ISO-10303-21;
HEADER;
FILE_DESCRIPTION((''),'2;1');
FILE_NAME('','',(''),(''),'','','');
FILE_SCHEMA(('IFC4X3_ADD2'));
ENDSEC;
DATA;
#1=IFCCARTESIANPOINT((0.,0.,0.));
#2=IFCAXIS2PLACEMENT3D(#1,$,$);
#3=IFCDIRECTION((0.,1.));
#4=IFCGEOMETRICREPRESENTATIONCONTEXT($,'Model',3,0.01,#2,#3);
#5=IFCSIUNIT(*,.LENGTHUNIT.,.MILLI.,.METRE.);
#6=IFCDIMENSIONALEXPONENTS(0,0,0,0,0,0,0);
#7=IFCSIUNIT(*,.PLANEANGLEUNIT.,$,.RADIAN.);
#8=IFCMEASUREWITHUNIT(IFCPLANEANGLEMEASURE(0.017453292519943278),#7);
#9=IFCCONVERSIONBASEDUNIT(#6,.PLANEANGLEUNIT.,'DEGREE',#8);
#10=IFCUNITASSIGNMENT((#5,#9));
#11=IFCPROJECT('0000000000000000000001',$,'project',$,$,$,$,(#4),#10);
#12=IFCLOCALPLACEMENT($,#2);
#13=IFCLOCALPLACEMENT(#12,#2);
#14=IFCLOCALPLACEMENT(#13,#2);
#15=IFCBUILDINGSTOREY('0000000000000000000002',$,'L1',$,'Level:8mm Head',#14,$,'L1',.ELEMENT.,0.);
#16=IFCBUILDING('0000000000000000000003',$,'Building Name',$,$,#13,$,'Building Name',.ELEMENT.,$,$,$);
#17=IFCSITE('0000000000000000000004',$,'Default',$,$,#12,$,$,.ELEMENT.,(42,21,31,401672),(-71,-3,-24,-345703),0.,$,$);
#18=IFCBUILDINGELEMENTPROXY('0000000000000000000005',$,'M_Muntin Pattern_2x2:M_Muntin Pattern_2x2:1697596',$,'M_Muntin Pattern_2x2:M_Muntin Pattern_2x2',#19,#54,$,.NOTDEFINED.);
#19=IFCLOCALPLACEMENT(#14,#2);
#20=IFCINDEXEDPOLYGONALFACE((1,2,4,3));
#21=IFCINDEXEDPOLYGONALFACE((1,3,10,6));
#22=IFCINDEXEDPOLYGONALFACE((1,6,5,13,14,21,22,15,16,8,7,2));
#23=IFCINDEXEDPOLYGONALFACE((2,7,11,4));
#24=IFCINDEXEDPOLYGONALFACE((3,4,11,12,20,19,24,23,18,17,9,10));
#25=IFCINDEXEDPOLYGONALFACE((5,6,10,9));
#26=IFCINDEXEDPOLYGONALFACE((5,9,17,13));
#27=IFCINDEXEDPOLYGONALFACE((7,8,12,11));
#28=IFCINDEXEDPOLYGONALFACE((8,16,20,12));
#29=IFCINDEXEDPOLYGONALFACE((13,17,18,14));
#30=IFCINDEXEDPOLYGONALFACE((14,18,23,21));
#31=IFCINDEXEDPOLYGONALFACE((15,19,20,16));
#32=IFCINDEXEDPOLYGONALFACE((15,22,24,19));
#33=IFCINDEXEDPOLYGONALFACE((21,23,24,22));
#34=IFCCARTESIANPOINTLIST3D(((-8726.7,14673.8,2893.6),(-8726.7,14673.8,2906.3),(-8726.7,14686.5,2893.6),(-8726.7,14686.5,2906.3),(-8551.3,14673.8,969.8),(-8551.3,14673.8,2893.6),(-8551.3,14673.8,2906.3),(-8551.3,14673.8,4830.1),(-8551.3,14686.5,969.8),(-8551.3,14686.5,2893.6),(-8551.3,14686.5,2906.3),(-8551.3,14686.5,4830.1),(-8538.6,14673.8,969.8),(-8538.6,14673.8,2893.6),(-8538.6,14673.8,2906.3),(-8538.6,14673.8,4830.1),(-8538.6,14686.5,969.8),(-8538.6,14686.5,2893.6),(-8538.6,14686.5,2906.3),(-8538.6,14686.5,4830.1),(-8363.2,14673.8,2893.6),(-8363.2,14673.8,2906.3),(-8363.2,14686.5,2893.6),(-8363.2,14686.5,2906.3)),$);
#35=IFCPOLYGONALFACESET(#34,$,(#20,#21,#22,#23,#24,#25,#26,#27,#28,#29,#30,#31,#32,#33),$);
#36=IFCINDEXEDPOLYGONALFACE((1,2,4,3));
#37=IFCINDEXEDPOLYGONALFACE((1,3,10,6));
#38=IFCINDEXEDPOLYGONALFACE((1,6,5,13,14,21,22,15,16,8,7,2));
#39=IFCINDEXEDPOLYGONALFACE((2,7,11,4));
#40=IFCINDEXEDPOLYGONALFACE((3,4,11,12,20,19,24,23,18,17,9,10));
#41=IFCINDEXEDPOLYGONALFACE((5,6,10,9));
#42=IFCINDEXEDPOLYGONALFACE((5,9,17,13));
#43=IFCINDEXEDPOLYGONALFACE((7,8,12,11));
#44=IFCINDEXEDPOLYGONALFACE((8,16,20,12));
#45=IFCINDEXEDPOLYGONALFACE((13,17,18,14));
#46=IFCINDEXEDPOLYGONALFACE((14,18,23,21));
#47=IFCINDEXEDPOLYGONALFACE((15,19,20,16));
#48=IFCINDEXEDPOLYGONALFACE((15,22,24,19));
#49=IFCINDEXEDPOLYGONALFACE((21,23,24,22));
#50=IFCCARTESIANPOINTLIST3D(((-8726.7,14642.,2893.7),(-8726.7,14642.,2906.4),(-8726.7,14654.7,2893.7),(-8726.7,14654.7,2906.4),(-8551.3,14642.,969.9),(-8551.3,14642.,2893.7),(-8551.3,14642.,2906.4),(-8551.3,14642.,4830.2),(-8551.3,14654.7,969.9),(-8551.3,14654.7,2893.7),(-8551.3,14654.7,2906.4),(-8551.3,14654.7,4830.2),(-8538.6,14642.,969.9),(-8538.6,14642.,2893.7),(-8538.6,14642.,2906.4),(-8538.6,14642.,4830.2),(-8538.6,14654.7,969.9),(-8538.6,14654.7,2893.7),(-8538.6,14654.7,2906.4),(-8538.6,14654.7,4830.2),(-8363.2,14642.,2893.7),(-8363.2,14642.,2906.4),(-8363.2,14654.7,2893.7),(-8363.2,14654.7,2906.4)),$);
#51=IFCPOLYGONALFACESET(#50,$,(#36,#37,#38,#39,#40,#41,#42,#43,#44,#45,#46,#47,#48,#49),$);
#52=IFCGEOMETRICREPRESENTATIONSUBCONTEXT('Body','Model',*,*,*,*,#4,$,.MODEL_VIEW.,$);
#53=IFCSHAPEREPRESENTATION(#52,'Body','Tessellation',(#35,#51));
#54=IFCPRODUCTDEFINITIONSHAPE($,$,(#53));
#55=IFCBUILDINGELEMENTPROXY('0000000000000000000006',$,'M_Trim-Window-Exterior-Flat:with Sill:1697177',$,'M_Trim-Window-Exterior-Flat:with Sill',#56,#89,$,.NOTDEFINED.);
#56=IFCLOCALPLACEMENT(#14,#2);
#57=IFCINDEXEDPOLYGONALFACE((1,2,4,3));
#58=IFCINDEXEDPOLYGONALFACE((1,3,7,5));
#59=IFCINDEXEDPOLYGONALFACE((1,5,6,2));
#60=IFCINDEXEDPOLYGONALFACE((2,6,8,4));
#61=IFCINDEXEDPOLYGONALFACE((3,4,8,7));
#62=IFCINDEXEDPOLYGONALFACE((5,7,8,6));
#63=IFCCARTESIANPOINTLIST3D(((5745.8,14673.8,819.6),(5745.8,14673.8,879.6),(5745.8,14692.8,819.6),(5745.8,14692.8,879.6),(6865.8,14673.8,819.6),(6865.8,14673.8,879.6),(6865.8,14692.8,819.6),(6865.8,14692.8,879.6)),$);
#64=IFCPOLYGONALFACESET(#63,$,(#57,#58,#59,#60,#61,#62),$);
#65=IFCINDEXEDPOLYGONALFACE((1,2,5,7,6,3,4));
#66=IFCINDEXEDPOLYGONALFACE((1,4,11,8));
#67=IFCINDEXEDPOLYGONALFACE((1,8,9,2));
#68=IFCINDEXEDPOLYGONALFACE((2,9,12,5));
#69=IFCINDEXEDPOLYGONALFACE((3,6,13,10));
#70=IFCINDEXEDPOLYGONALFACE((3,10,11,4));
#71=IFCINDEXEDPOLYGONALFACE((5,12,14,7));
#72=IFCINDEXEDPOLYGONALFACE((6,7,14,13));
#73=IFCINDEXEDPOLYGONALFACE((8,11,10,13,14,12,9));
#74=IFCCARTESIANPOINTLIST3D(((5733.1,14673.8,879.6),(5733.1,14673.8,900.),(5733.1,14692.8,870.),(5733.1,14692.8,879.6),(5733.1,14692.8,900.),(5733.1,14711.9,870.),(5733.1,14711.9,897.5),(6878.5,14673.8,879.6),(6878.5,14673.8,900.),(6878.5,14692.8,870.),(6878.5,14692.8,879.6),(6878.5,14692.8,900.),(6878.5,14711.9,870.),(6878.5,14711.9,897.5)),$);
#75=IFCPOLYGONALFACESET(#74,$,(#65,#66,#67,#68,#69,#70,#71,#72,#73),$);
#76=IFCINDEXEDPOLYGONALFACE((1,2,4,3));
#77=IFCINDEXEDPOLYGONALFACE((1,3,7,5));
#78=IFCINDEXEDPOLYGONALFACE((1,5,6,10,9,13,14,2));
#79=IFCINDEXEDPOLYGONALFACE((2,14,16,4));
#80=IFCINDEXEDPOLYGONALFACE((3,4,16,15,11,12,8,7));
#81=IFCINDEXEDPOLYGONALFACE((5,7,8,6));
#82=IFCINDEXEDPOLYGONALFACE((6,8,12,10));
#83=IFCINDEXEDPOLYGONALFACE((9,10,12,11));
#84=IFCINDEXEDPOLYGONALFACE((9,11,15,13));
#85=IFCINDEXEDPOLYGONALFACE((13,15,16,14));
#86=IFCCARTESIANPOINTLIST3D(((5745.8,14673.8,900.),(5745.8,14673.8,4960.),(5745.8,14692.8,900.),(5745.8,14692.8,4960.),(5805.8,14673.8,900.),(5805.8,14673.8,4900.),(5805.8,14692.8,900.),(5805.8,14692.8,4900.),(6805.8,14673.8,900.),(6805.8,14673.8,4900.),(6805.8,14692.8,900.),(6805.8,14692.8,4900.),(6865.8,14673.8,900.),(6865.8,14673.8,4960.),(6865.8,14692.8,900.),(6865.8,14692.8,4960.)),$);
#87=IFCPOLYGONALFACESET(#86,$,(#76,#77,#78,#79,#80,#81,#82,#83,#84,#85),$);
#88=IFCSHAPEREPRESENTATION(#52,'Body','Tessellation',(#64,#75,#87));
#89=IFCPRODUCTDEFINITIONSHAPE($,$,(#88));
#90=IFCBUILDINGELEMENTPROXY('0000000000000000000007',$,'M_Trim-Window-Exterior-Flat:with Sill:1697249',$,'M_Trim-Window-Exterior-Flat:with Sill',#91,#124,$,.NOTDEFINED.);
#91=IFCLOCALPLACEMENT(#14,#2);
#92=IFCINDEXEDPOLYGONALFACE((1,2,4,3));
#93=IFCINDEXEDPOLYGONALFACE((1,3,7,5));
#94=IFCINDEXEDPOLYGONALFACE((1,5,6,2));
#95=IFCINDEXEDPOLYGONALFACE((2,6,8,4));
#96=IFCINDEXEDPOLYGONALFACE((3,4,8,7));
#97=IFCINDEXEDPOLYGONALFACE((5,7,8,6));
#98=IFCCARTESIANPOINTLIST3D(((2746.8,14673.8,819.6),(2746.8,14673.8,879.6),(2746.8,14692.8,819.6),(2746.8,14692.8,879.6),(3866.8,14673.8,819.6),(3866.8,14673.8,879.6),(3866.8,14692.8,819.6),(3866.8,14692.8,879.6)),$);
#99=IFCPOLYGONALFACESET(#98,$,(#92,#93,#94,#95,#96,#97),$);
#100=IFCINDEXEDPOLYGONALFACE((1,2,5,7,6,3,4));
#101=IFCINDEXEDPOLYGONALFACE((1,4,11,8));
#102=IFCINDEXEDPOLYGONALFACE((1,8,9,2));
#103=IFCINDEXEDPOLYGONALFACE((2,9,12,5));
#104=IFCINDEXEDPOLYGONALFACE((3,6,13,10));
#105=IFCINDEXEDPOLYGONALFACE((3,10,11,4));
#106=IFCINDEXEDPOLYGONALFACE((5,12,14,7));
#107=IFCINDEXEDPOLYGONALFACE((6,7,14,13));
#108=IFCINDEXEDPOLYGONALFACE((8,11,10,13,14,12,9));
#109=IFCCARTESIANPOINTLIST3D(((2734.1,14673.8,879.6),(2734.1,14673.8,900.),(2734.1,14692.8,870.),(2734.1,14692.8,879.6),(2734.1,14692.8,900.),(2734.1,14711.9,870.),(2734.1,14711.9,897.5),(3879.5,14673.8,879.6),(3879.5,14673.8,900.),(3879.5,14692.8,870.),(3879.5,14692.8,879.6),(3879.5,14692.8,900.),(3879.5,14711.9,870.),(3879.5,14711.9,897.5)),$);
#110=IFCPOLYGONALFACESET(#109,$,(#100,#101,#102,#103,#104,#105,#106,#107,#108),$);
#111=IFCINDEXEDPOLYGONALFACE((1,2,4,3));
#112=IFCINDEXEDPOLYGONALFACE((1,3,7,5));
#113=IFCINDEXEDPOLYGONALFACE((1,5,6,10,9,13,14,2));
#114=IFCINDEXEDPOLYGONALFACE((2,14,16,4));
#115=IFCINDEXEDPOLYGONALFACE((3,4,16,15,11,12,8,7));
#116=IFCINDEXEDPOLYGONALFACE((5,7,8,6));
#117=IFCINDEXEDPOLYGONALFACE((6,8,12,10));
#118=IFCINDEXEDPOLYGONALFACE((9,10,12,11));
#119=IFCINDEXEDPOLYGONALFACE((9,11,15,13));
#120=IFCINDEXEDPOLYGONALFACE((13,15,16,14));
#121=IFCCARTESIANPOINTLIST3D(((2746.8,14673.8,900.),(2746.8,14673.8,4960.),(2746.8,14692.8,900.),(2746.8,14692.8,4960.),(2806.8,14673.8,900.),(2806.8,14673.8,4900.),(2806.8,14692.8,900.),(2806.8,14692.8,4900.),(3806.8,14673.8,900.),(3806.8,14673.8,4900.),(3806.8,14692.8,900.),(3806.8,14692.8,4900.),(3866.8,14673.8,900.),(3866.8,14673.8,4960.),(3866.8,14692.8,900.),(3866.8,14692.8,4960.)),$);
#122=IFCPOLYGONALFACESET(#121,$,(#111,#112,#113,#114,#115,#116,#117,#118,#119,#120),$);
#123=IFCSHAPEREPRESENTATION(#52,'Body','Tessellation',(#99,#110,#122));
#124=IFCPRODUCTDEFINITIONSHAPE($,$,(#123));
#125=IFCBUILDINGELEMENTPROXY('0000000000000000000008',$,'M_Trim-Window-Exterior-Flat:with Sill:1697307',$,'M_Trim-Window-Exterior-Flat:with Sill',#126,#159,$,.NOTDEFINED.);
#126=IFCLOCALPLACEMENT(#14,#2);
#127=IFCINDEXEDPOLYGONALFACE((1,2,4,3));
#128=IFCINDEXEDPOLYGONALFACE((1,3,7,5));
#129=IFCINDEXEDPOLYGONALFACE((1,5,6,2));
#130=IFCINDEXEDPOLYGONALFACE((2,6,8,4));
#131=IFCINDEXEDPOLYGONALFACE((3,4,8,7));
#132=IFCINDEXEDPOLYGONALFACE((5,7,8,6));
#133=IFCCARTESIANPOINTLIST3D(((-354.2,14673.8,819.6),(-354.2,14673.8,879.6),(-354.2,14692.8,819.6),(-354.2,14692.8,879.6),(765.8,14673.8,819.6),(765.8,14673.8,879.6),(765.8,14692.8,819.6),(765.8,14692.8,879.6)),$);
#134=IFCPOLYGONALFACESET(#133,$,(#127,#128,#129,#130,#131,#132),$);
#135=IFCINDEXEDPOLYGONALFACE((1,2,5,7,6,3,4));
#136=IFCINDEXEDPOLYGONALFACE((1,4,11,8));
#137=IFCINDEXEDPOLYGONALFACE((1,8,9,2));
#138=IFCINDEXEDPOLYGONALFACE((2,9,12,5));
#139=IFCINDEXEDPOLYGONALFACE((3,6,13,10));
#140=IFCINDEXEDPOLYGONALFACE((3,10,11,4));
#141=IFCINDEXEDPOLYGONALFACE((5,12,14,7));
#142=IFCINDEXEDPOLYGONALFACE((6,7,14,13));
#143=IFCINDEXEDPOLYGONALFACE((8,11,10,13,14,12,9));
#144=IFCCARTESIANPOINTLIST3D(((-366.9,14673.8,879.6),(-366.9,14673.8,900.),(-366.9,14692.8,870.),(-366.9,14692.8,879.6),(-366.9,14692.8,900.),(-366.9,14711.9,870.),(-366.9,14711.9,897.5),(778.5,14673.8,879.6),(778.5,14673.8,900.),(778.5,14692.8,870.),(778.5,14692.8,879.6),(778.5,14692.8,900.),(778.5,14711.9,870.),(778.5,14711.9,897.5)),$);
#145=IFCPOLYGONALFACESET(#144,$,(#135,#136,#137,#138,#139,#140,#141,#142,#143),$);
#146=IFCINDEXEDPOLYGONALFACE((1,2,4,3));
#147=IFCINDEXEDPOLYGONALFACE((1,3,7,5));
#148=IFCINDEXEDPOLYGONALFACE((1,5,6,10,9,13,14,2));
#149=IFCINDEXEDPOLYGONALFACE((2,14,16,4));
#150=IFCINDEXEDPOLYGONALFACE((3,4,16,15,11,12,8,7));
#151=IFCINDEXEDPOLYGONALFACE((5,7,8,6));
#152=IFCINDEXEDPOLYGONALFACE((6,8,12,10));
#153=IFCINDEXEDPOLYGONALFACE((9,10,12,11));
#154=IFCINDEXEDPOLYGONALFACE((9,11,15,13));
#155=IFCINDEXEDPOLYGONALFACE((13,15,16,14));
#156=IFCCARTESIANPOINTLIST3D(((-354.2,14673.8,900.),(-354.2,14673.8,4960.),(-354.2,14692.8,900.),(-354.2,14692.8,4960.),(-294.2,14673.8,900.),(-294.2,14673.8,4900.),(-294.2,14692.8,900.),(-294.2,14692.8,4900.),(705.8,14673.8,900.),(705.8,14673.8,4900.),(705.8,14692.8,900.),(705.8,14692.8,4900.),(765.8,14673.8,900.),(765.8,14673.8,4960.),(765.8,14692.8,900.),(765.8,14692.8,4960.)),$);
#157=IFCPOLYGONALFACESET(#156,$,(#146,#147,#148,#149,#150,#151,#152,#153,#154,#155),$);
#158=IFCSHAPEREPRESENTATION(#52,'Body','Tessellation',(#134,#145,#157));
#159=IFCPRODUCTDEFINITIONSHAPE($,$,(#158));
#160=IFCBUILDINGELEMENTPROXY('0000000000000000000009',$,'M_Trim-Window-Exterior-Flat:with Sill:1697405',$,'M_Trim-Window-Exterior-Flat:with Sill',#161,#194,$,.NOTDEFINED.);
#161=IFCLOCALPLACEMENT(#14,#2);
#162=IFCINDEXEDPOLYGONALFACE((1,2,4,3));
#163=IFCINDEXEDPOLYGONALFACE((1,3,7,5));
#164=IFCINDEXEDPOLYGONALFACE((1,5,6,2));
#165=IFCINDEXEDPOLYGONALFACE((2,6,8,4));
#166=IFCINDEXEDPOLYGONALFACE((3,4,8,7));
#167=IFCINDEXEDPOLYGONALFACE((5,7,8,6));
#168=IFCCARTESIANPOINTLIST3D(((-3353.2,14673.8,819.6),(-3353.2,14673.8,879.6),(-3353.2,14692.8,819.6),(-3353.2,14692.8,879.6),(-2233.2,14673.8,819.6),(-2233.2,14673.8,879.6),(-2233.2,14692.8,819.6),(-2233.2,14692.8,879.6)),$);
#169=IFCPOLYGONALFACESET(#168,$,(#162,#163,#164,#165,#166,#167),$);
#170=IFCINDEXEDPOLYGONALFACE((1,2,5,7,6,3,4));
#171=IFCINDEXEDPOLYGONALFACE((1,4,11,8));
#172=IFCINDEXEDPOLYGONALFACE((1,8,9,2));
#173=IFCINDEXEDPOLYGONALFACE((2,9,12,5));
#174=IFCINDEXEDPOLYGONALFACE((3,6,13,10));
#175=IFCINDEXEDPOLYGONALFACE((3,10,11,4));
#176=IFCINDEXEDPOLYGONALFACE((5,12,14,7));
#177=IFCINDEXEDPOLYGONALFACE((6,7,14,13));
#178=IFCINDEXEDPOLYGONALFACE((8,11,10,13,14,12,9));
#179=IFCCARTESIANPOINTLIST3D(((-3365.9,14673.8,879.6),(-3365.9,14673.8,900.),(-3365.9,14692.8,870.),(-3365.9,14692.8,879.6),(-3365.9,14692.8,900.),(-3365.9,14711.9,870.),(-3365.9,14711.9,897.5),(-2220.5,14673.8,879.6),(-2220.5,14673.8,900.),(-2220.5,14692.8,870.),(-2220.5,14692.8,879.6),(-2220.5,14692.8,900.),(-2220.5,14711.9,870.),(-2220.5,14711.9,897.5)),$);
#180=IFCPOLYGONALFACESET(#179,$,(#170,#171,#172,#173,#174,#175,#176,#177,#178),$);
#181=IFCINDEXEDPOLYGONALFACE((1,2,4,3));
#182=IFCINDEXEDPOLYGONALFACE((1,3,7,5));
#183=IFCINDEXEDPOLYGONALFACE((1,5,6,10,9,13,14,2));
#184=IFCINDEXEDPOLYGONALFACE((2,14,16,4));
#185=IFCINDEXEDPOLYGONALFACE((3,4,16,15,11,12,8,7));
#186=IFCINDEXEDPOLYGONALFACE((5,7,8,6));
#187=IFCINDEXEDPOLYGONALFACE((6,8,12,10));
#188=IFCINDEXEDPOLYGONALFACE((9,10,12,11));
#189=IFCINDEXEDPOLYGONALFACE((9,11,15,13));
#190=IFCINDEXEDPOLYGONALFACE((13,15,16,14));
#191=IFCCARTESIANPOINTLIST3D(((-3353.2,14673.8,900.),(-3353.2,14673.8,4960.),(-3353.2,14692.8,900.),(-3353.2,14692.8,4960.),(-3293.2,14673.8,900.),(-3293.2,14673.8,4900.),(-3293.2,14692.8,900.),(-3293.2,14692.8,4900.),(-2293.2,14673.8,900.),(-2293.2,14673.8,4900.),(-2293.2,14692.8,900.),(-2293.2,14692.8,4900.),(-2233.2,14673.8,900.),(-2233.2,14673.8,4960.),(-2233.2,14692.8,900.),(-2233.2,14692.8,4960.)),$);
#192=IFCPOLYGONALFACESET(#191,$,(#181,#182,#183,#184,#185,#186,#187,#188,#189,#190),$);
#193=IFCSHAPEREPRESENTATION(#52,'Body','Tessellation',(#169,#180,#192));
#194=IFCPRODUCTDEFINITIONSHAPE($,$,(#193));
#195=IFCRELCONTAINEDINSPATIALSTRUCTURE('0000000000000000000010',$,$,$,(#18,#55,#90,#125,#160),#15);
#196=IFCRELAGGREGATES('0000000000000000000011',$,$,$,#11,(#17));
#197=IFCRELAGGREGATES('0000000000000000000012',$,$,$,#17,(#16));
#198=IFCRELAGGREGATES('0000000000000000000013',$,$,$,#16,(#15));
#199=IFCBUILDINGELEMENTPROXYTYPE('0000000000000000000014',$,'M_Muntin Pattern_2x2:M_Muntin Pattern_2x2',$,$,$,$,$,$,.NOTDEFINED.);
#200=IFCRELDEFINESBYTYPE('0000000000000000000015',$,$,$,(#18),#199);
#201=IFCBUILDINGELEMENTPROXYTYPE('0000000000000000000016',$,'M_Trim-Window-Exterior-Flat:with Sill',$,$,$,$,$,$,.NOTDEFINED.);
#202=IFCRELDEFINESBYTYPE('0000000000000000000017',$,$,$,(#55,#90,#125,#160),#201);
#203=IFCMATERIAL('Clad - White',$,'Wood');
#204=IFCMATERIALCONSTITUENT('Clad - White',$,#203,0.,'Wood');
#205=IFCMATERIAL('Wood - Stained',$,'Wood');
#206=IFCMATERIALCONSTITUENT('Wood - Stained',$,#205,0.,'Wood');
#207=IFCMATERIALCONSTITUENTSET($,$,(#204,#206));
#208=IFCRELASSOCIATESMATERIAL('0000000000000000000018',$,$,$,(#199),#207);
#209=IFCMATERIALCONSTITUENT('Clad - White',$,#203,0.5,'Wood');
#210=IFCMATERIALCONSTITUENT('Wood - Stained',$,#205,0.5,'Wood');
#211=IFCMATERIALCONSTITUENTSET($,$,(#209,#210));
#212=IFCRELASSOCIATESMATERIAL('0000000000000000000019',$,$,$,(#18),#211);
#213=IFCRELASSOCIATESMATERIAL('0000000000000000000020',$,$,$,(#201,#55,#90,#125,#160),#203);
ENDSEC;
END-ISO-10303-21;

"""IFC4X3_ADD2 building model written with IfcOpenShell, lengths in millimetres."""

from ifc_helpers import new_model, entity, si_unit, converted_unit, direction, frame, frame_2d, origin, place, context, subcontext, project, spatial, polyline, rectangle, outline, extrude, source, transform, mapped, material, constituent, constituent_set, type_object, type_shapes, element, save


model = new_model("IFC4X3_ADD2")

# Units and contexts
model_context = context("Model", 3, precision=0.01, world=origin(), true_north=direction((0.0, 1.0)))
body_context = subcontext(model_context, "Body", "Model", "MODEL_VIEW")
ifc_project = project(units=[si_unit("LENGTHUNIT", "METRE", prefix="MILLI"), converted_unit("PLANEANGLEUNIT", "DEGREE", entity("IfcPlaneAngleMeasure", 0.017453292519943278), si_unit("PLANEANGLEUNIT", "RADIAN"), dimensions=[0, 0, 0, 0, 0, 0, 0])], contexts=[model_context])

# Site, building, storey
site_placement = place(None, origin())
site = spatial("IfcSite", under=ifc_project, at=site_placement, Name="Default", CompositionType="ELEMENT", RefLatitude=(42, 21, 31, 401672), RefLongitude=(-71, -3, -24, -345703), RefElevation=0.0)
building_placement = place(site_placement, origin())
building = spatial("IfcBuilding", under=site, at=building_placement, Name="Building Name", LongName="Building Name", CompositionType="ELEMENT")
storey_placement = place(building_placement, origin())
storey = spatial("IfcBuildingStorey", under=building, at=storey_placement, Name="L1", ObjectType="Level:8mm Head", LongName="L1", CompositionType="ELEMENT", Elevation=0.0)

# Building element proxies
ifc_material_1 = material(Name="Clad - White", Category="Wood")
ifc_material_2 = material(Name="Wood - Stained", Category="Wood")
ifc_constituent_1 = constituent(ifc_material_1, Name="Clad - White", Category="Wood", fraction=0.0)
ifc_constituent_2 = constituent(ifc_material_2, Name="Wood - Stained", Category="Wood", fraction=0.0)
ifc_constituent_set_1 = constituent_set(constituents=[ifc_constituent_1, ifc_constituent_2])
building_element_proxy_type_1 = type_object("IfcBuildingElementProxyType", Name="M_Muntin Pattern_2x2:M_Muntin Pattern_2x2", PredefinedType="NOTDEFINED", material=ifc_constituent_set_1)
shared_shape_1 = source(origin(), body_context, "Body", "SweptSolid", [
    extrude(outline(polyline([(6.4, -6.4), (1930.1, -6.4), (1930.1, 6.3), (6.4, 6.3), (6.4, 181.7), (-6.3, 181.7), (-6.3, 6.3), (-1930.2, 6.3), (-1930.2, -6.4), (-6.3, -6.4), (-6.3, -181.7), (6.4, -181.7), (6.4, -6.4)])), frame((0.0, -22.2, 1930.1), z_axis=(0.0, 1.0, 0.0), x_axis=(0.0, 0.0, 1.0)), (0.0, 0.0, 1.0), 12.7),
    extrude(outline(polyline([(6.4, -6.4), (1930.2, -6.4), (1930.2, 6.3), (6.4, 6.3), (6.4, 181.7), (-6.3, 181.7), (-6.3, 6.3), (-1930.2, 6.3), (-1930.2, -6.4), (-6.3, -6.4), (-6.3, -181.7), (6.4, -181.7), (6.4, -6.4)])), frame((0.0, 9.5, 1930.2), z_axis=(0.0, 1.0, 0.0), x_axis=(0.0, 0.0, 1.0)), (0.0, 0.0, 1.0), 12.7),
])
type_shapes(building_element_proxy_type_1, [shared_shape_1])
ifc_constituent_3 = constituent(ifc_material_1, Name="Clad - White", Category="Wood", fraction=0.5)
ifc_constituent_4 = constituent(ifc_material_2, Name="Wood - Stained", Category="Wood", fraction=0.5)
ifc_constituent_set_2 = constituent_set(constituents=[ifc_constituent_3, ifc_constituent_4])
proxy_1_placement = place(storey_placement, frame((-8544.9, 14664.3, 969.9), z_axis=(0.0, 0.0, 1.0), x_axis=(-1.0, 0.0, 0.0)))
element("IfcBuildingElementProxy", 1, at=proxy_1_placement, inside=storey, type_object=building_element_proxy_type_1, material=ifc_constituent_set_2, Name="M_Muntin Pattern_2x2:M_Muntin Pattern_2x2:1697596", ObjectType="M_Muntin Pattern_2x2:M_Muntin Pattern_2x2", PredefinedType="NOTDEFINED", context=body_context, shape_type="MappedRepresentation", body=[
    mapped(shared_shape_1, transform((0.0, 0.0, 0.0), scale=1.0)),
])
building_element_proxy_type_2 = type_object("IfcBuildingElementProxyType", Name="M_Trim-Window-Exterior-Flat:with Sill", PredefinedType="NOTDEFINED", material=ifc_material_1)
shared_shape_2 = source(origin(), body_context, "Body", "SweptSolid", [
    extrude(rectangle(XDim=1120.0, YDim=60.0, at=frame_2d((0.0, 0.0), x_axis=(1.0, 0.0))), frame((0.0, -4050.4, 0.0), z_axis=(0.0, 0.0, 1.0), x_axis=(-1.0, 0.0, 0.0)), (0.0, 0.0, 1.0), 19.0),
    extrude(outline(polyline([(-19.0, -15.2), (0.0, -15.2), (0.0, -5.7), (19.0, -5.7), (19.0, 14.8), (0.0, 14.8), (-19.0, 12.3), (-19.0, -15.2)])), frame((-572.7, -4014.8, 19.0), z_axis=(1.0, 0.0, 0.0), x_axis=(0.0, 0.0, -1.0)), (0.0, 0.0, 1.0), 1145.4),
    extrude(outline(polyline([(-2045.0, -560.0), (2015.0, -560.0), (2015.0, -500.0), (-1985.0, -500.0), (-1985.0, 500.0), (2015.0, 500.0), (2015.0, 560.0), (-2045.0, 560.0), (-2045.0, -560.0)])), frame((0.0, -1985.0, 0.0), z_axis=(0.0, 0.0, 1.0), x_axis=(0.0, -1.0, 0.0)), (0.0, 0.0, 1.0), 19.0),
])
type_shapes(building_element_proxy_type_2, [shared_shape_2])
for number, where, z_axis, x_axis, name in (
    (2, (6305.8, 14673.8, 4900.0), (0.0, 1.0, 0.0), (-1.0, 0.0, 0.0), "M_Trim-Window-Exterior-Flat:with Sill:1697177"),
    (3, (3306.8, 14673.8, 4900.0), (0.0, 1.0, 0.0), (-1.0, 0.0, 0.0), "M_Trim-Window-Exterior-Flat:with Sill:1697249"),
    (4, (205.8, 14673.8, 4900.0), (0.0, 1.0, 0.0), (-1.0, 0.0, 0.0), "M_Trim-Window-Exterior-Flat:with Sill:1697307"),
    (5, (-2793.2, 14673.8, 4900.0), (0.0, 1.0, 0.0), (-1.0, 0.0, 0.0), "M_Trim-Window-Exterior-Flat:with Sill:1697405"),
):
    element("IfcBuildingElementProxy", number, at=place(storey_placement, frame(where, z_axis=z_axis, x_axis=x_axis)), inside=storey, type_object=building_element_proxy_type_2, material=ifc_material_1, Name=name, ObjectType="M_Trim-Window-Exterior-Flat:with Sill", PredefinedType="NOTDEFINED", context=body_context, shape_type="MappedRepresentation", body=[
        mapped(shared_shape_2, transform((0.0, 0.0, 0.0), scale=1.0)),
    ])

save(model, "model.ifc")
